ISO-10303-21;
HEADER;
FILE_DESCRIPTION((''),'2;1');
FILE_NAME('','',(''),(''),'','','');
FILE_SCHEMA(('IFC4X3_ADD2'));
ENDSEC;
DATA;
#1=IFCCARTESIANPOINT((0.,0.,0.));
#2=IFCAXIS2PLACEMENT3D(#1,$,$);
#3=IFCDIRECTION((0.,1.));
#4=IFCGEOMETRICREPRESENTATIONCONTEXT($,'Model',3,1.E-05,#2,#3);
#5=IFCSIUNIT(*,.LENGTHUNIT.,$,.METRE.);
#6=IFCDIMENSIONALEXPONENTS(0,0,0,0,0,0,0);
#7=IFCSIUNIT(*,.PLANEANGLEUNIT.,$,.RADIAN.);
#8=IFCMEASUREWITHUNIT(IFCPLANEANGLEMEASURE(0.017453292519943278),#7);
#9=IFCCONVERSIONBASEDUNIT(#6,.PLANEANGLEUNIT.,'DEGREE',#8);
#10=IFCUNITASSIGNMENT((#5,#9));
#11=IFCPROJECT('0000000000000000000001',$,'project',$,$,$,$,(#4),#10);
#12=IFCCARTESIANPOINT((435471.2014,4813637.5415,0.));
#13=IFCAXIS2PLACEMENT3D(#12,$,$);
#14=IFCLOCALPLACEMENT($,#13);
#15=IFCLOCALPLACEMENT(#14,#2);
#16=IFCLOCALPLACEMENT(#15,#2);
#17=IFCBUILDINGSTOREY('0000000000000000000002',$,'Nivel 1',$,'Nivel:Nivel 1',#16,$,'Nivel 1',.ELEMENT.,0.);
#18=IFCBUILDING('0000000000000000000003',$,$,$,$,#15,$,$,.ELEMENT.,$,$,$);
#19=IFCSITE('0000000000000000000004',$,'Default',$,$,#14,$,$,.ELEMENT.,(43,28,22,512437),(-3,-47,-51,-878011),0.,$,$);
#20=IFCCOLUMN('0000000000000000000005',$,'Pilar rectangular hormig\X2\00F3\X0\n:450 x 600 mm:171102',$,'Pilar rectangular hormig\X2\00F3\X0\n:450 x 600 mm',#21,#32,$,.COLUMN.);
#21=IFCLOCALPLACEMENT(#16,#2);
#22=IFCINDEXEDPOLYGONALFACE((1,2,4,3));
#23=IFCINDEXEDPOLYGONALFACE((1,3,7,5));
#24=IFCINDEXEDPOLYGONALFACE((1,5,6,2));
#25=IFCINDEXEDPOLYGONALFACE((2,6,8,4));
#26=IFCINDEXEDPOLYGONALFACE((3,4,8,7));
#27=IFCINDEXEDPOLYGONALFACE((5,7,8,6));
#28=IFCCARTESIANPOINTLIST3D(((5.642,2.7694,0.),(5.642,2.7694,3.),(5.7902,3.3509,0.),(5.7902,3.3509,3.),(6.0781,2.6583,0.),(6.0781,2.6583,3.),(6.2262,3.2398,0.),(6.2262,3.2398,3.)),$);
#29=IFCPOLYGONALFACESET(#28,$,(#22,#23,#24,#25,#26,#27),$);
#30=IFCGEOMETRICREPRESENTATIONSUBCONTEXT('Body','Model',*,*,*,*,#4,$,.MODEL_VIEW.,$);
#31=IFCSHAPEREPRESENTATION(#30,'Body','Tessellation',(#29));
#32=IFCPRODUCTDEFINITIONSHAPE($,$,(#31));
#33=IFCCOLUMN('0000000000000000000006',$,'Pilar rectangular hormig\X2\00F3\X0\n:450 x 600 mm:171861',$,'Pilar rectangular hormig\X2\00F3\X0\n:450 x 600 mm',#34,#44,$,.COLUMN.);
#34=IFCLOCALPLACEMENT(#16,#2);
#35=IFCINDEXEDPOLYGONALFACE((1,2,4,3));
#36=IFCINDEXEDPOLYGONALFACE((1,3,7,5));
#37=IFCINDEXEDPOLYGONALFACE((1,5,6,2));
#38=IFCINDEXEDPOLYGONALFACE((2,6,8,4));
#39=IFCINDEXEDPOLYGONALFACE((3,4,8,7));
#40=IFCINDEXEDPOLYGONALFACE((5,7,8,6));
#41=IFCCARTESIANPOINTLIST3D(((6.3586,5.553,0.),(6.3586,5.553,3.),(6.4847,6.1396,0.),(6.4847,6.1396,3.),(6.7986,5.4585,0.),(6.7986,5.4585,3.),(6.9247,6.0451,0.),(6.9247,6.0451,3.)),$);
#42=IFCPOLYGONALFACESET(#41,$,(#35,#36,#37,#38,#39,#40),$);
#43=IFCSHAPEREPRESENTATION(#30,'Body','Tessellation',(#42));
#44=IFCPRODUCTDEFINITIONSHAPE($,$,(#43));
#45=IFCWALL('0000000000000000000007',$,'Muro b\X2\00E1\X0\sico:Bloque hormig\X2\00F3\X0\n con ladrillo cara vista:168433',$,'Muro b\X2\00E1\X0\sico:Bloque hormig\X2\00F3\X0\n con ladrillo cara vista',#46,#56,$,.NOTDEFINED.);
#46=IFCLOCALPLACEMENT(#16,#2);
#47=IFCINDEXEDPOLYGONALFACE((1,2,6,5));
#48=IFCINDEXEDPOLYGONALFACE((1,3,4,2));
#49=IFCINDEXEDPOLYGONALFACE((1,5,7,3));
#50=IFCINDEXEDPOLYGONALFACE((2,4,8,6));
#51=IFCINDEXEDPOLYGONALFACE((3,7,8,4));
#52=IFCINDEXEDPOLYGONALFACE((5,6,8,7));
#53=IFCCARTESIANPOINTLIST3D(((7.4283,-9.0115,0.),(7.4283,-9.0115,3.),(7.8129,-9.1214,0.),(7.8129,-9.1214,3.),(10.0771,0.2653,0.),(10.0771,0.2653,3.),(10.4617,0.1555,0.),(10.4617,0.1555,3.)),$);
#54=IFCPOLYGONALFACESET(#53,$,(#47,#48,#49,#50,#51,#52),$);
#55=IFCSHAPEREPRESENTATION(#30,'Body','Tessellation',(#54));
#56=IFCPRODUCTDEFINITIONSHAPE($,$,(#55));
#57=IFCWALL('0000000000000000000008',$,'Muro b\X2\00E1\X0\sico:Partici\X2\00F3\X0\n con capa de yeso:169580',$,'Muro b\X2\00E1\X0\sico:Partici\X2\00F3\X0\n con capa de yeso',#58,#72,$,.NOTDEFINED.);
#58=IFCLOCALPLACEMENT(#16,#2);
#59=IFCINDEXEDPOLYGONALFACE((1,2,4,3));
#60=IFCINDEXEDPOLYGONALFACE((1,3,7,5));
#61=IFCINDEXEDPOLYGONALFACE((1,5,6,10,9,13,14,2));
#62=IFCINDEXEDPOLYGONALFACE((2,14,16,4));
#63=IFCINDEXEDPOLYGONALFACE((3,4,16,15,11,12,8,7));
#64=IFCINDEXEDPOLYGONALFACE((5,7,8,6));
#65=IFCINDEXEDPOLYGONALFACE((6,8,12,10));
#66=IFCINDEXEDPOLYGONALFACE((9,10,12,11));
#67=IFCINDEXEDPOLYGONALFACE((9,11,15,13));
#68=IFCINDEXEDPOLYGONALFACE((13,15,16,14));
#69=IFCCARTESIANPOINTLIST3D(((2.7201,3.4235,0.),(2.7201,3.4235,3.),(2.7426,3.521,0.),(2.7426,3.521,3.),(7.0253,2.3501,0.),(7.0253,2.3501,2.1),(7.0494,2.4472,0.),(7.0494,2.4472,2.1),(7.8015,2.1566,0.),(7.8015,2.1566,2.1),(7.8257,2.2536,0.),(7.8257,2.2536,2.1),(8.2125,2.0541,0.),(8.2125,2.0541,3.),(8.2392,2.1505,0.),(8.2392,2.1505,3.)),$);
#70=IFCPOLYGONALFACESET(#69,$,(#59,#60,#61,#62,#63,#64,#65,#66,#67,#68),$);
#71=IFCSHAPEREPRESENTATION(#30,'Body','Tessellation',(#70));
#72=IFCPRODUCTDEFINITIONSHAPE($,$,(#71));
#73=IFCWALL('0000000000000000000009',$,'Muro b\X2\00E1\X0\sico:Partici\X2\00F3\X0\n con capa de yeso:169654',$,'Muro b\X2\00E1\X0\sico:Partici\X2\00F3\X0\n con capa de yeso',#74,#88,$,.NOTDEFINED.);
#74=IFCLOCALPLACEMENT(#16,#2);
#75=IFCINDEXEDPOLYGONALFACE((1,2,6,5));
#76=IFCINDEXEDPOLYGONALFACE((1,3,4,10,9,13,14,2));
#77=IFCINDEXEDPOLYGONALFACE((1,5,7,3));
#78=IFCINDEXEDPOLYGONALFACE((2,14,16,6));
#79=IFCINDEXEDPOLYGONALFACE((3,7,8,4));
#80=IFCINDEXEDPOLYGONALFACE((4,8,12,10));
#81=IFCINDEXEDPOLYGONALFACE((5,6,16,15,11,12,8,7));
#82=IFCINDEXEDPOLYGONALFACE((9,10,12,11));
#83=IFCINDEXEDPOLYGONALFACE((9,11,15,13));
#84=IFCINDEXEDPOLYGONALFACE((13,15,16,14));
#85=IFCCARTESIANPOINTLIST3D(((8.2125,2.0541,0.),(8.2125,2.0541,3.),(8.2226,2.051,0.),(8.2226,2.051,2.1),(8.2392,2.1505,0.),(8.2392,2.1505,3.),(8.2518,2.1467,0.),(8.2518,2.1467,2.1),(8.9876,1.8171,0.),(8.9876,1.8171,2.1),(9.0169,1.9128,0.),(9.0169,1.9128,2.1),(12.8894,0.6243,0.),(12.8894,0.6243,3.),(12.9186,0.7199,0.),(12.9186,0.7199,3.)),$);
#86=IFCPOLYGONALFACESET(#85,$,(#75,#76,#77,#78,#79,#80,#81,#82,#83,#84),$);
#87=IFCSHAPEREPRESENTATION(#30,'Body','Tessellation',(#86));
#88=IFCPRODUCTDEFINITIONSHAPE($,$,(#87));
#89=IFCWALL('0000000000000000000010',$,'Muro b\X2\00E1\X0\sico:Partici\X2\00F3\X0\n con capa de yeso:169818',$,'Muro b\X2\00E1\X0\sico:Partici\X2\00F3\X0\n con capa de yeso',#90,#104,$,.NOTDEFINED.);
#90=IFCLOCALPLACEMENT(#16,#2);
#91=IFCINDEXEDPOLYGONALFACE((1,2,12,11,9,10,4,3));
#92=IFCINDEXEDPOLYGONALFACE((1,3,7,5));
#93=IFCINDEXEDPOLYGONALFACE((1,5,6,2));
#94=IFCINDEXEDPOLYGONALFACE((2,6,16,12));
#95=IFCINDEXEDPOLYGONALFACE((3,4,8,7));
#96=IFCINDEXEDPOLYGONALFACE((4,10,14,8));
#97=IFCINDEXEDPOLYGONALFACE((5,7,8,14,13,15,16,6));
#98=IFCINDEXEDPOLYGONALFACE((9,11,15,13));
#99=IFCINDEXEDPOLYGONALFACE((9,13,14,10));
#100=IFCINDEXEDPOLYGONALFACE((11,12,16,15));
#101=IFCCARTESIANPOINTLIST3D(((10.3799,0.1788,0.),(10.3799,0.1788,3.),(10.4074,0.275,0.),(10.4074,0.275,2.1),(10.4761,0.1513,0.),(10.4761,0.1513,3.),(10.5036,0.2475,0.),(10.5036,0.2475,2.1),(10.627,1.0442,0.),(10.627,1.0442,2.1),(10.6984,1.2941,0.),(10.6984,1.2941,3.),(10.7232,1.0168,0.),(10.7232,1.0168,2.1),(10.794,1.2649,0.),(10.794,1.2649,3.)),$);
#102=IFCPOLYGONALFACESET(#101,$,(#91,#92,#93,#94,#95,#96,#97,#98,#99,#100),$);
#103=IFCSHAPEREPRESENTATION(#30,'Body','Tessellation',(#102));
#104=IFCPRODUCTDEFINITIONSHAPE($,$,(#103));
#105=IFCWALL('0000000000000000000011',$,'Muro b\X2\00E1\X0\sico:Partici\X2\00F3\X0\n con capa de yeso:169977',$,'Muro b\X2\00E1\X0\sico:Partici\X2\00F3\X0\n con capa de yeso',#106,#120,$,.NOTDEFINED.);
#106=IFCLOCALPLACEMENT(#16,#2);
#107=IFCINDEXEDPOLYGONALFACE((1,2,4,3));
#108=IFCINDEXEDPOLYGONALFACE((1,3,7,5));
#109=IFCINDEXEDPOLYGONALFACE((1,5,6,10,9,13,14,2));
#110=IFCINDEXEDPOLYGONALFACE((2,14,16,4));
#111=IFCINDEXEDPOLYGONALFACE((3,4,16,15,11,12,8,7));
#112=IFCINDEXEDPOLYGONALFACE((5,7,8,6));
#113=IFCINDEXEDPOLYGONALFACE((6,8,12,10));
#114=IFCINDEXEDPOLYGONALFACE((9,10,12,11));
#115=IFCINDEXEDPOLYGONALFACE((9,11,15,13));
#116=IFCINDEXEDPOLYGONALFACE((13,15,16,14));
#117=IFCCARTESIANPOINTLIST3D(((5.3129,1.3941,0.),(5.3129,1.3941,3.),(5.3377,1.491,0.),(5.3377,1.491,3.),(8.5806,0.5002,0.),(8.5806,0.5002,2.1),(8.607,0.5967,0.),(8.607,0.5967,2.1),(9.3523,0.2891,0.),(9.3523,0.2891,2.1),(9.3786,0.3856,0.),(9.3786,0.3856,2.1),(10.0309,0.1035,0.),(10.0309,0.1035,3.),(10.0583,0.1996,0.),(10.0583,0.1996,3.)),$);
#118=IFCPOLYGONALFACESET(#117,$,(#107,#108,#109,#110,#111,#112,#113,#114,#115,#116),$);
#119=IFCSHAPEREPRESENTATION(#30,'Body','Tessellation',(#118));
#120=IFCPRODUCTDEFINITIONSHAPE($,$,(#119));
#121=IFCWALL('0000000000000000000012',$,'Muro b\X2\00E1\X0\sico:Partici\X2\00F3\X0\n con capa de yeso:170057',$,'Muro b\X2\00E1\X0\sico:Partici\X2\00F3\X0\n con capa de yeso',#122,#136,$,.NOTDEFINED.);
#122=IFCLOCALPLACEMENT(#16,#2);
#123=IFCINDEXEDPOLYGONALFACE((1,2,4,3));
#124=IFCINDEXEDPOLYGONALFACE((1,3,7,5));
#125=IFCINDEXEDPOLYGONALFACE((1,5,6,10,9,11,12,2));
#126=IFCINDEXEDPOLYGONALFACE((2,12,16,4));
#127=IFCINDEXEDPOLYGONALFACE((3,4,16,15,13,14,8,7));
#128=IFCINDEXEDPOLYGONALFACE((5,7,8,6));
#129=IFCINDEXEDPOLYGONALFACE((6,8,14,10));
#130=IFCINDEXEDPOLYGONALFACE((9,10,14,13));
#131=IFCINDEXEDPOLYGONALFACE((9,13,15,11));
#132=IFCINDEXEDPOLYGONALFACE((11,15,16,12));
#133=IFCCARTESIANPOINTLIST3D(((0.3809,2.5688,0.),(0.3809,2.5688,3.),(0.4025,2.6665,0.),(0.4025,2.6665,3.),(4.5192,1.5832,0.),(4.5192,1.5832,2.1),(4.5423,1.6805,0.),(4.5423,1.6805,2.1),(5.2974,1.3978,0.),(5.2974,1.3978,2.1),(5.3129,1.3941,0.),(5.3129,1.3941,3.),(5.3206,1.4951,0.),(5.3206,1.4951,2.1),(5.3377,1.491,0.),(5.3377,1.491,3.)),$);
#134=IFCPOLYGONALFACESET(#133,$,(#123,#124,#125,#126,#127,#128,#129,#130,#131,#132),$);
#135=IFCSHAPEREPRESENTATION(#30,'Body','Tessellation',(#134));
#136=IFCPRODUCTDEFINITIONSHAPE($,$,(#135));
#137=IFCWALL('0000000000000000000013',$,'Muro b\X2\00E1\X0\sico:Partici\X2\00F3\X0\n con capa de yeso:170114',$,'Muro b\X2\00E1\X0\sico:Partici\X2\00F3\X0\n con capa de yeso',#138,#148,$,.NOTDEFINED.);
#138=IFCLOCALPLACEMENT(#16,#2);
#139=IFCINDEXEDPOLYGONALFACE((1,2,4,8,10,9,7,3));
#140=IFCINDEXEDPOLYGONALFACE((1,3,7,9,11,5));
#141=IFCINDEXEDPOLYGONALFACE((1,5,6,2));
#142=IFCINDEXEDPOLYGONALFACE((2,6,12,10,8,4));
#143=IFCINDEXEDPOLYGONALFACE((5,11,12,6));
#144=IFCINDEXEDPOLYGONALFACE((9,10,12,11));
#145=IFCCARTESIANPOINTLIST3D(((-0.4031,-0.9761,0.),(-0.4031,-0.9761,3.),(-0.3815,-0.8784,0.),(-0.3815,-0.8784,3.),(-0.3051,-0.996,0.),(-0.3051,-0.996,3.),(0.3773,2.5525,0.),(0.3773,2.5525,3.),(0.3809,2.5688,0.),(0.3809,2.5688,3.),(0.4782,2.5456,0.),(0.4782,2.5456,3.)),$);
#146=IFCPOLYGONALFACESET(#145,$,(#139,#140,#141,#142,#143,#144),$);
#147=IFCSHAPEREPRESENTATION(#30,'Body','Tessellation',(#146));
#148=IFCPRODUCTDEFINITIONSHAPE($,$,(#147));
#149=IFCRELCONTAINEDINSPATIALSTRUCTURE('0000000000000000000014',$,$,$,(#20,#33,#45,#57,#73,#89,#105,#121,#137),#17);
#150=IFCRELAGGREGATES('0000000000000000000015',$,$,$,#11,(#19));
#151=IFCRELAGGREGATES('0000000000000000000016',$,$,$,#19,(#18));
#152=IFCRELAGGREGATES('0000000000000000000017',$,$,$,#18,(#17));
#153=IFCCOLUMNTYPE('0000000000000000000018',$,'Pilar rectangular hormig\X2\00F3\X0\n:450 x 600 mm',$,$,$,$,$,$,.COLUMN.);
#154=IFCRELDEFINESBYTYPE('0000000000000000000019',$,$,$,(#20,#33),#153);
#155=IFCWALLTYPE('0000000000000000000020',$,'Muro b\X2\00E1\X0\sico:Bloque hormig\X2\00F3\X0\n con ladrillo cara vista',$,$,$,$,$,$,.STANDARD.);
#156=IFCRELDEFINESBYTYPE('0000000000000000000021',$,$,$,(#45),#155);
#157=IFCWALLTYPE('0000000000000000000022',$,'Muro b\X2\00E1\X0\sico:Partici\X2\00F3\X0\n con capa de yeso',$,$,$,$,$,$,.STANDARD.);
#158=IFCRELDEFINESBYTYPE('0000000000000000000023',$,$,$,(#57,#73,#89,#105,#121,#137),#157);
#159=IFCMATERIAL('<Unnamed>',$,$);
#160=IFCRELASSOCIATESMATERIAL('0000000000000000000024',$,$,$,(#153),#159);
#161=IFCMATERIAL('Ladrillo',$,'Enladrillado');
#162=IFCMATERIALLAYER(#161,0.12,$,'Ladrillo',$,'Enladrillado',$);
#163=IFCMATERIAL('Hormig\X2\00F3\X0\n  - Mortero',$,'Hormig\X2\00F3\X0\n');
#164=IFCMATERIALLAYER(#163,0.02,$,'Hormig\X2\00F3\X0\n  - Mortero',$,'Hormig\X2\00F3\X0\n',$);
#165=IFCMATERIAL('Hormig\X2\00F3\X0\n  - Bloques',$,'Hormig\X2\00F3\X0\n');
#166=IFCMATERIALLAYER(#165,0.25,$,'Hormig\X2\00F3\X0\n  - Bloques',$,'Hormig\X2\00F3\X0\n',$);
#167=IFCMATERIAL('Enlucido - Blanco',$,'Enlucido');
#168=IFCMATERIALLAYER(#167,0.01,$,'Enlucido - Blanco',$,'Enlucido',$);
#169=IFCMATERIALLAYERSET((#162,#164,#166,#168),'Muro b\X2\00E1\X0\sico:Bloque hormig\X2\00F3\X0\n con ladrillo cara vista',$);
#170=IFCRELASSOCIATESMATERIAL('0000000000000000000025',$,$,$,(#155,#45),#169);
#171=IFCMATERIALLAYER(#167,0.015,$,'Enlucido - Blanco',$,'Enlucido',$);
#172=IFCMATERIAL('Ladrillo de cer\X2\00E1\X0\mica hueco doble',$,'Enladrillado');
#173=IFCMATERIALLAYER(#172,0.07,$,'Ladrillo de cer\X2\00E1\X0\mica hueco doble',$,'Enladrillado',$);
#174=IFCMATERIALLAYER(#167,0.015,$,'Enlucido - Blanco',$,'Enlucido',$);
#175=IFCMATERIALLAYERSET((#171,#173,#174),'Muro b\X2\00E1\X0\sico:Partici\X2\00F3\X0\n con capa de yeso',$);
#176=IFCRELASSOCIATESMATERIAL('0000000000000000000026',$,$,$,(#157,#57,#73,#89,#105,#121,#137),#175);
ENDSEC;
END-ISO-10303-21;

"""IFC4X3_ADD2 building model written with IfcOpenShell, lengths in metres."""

from ifc_helpers import new_model, entity, si_unit, converted_unit, direction, frame, frame_2d, origin, origin_2d_with_axis, place, context, subcontext, project, spatial, polyline, rectangle, outline, extrude, source, transform, mapped, material, layer, layer_set, material_profile, profile_set, type_object, type_shapes, element, save


model = new_model("IFC4X3_ADD2")

# Units and contexts
model_context = context("Model", 3, precision=1e-05, world=origin(), true_north=direction((0.0, 1.0)))
body_context = subcontext(model_context, "Body", "Model", "MODEL_VIEW")
ifc_project = project(units=[si_unit("LENGTHUNIT", "METRE"), converted_unit("PLANEANGLEUNIT", "DEGREE", entity("IfcPlaneAngleMeasure", 0.017453292519943278), si_unit("PLANEANGLEUNIT", "RADIAN"), dimensions=[0, 0, 0, 0, 0, 0, 0])], contexts=[model_context])

# Site, building, storey
site_placement = place(None, frame((435471.2014, 4813637.5415, 0.0)))
site = spatial("IfcSite", under=ifc_project, at=site_placement, Name="Default", CompositionType="ELEMENT", RefLatitude=(43, 28, 22, 512437), RefLongitude=(-3, -47, -51, -878011), RefElevation=0.0)
building_placement = place(site_placement, origin())
building = spatial("IfcBuilding", under=site, at=building_placement, CompositionType="ELEMENT")
storey_placement = place(building_placement, origin())
storey = spatial("IfcBuildingStorey", under=building, at=storey_placement, Name="Nivel 1", ObjectType="Nivel:Nivel 1", LongName="Nivel 1", CompositionType="ELEMENT", Elevation=0.0)

# Columns
ifc_material_1 = material(Name="<Unnamed>")
ifc_material_profile = material_profile(ifc_material_1, rectangle(XDim=0.45, YDim=0.6, at=origin_2d_with_axis()), Name="450 x 600 mm")
ifc_profile_set = profile_set([ifc_material_profile], Name="450 x 600 mm")
column_type = type_object("IfcColumnType", Name="Pilar rectangular hormigón:450 x 600 mm", PredefinedType="COLUMN", material=ifc_profile_set)
shared_shape_1 = source(origin(), body_context, "Body", "SweptSolid", [
    extrude(rectangle(XDim=0.45, YDim=0.6, at=origin_2d_with_axis()), frame((0.0, 0.0, 0.0), z_axis=(0.0, 0.0, 1.0), x_axis=(-1.0, 0.0, 0.0)), (0.0, 0.0, 1.0), 3.0),
])
type_shapes(column_type, [shared_shape_1])
for number, where, z_axis, x_axis, name in (
    (1, (5.9341, 3.0046, 0.0), (0.0, 0.0, 1.0), (0.969039, -0.246908, 0.0), "Pilar rectangular hormigón:450 x 600 mm:171102"),
    (2, (6.6416, 5.799, 0.0), (0.0, 0.0, 1.0), (0.977667, -0.210159, 0.0), "Pilar rectangular hormigón:450 x 600 mm:171861"),
):
    element("IfcColumn", number, at=place(storey_placement, frame(where, z_axis=z_axis, x_axis=x_axis)), inside=storey, type_object=column_type, Name=name, ObjectType="Pilar rectangular hormigón:450 x 600 mm", PredefinedType="COLUMN", context=body_context, shape_type="MappedRepresentation", body=[
        mapped(shared_shape_1, transform((0.0, 0.0, 0.0), scale=1.0)),
    ])

# Shared definitions
ifc_material_2 = material(Name="Enlucido - Blanco", Category="Enlucido")

# Wall
ifc_material_3 = material(Name="Ladrillo", Category="Enladrillado")
ifc_layer_1 = layer(ifc_material_3, 0.12, Name="Ladrillo", Category="Enladrillado")
ifc_material_4 = material(Name="Hormigón  - Mortero", Category="Hormigón")
ifc_layer_2 = layer(ifc_material_4, 0.02, Name="Hormigón  - Mortero", Category="Hormigón")
ifc_material_5 = material(Name="Hormigón  - Bloques", Category="Hormigón")
ifc_layer_3 = layer(ifc_material_5, 0.25, Name="Hormigón  - Bloques", Category="Hormigón")
ifc_layer_4 = layer(ifc_material_2, 0.01, Name="Enlucido - Blanco", Category="Enlucido")
ifc_layer_set_1 = layer_set([ifc_layer_1, ifc_layer_2, ifc_layer_3, ifc_layer_4], Name="Muro básico:Bloque hormigón con ladrillo cara vista")
wall_type_1 = type_object("IfcWallType", Name="Muro básico:Bloque hormigón con ladrillo cara vista", PredefinedType="STANDARD", material=ifc_layer_set_1)
wall_1_placement = place(storey_placement, frame((10.2694, 0.2104, 0.0), z_axis=(0.0, 0.0, 1.0), x_axis=(-0.274552, -0.961572, 0.0)))
element("IfcWall", 3, at=wall_1_placement, inside=storey, type_object=wall_type_1, material=ifc_layer_set_1, Name="Muro básico:Bloque hormigón con ladrillo cara vista:168433", ObjectType="Muro básico:Bloque hormigón con ladrillo cara vista", PredefinedType="NOTDEFINED", context=body_context, shape_type="SweptSolid", body=[
    extrude(rectangle(XDim=9.6476, YDim=0.4, at=frame_2d((4.8238, 0.0), x_axis=(-1.0, 0.0))), origin(), (0.0, 0.0, 1.0), 3.0),
])

# Walls, openings
ifc_layer_5 = layer(ifc_material_2, 0.015, Name="Enlucido - Blanco", Category="Enlucido")
ifc_material_6 = material(Name="Ladrillo de cerámica hueco doble", Category="Enladrillado")
ifc_layer_6 = layer(ifc_material_6, 0.07, Name="Ladrillo de cerámica hueco doble", Category="Enladrillado")
ifc_layer_7 = layer(ifc_material_2, 0.015, Name="Enlucido - Blanco", Category="Enlucido")
ifc_layer_set_2 = layer_set([ifc_layer_5, ifc_layer_6, ifc_layer_7], Name="Muro básico:Partición con capa de yeso")
wall_type_2 = type_object("IfcWallType", Name="Muro básico:Partición con capa de yeso", PredefinedType="STANDARD", material=ifc_layer_set_2)
wall_2_placement = place(storey_placement, frame((2.7305, 3.4725, 0.0), z_axis=(0.0, 0.0, 1.0), x_axis=(0.970296, -0.241922, 0.0)))
wall_2 = element("IfcWall", 4, at=wall_2_placement, inside=storey, type_object=wall_type_2, material=ifc_layer_set_2, Name="Muro básico:Partición con capa de yeso:169580", ObjectType="Muro básico:Partición con capa de yeso", PredefinedType="NOTDEFINED", context=body_context, shape_type="SweptSolid", body=[
    extrude(outline(polyline([(0.0018, -0.05), (5.6622, -0.05), (5.6648, 0.05), (5.4827, 0.05), (5.3826, 0.05), (0.4693, 0.05), (0.3693, 0.05), (0.0, 0.05), (0.0018, -0.05)])), origin(), (0.0, 0.0, 1.0), 3.0),
])
opening_1_placement = place(wall_2_placement, frame((4.4387, -0.05, 0.0)))
element("IfcOpeningElement", 5, at=opening_1_placement, cuts=wall_2, PredefinedType="OPENING", context=body_context, shape_type="SweptSolid", body=[
    extrude(rectangle(XDim=2.1, YDim=0.8, at=frame_2d((1.05, 0.4), x_axis=(1.0, 0.0))), frame((0.0, 0.0, 0.0), z_axis=(0.0, 1.0, 0.0), x_axis=(0.0, 0.0, 1.0)), (0.0, 0.0, 1.0), 0.1),
])
wall_3_placement = place(storey_placement, frame((8.2246, 2.1027, 0.0), z_axis=(0.0, 0.0, 1.0), x_axis=(0.956305, -0.292372, 0.0)))
wall_3 = element("IfcWall", 6, at=wall_3_placement, inside=storey, type_object=wall_type_2, material=ifc_layer_set_2, Name="Muro básico:Partición con capa de yeso:169654", ObjectType="Muro básico:Partición con capa de yeso", PredefinedType="NOTDEFINED", context=body_context, shape_type="SweptSolid", body=[
    extrude(outline(polyline([(0.0026, -0.05), (2.6022, -0.05), (2.7022, -0.05), (4.8932, -0.05), (4.8932, 0.05), (0.0, 0.05), (0.0026, -0.05)])), origin(), (0.0, 0.0, 1.0), 3.0),
])
opening_2_placement = place(wall_3_placement, frame((0.0132, -0.05, 0.0)))
element("IfcOpeningElement", 7, at=opening_2_placement, cuts=wall_3, PredefinedType="OPENING", context=body_context, shape_type="SweptSolid", body=[
    extrude(rectangle(XDim=2.1, YDim=0.8, at=frame_2d((1.05, 0.4), x_axis=(1.0, 0.0))), frame((0.0, 0.0, 0.0), z_axis=(0.0, 1.0, 0.0), x_axis=(0.0, 0.0, 1.0)), (0.0, 0.0, 1.0), 0.1),
])
wall_4_placement = place(storey_placement, frame((10.7465, 1.2804, 0.0), z_axis=(0.0, 0.0, 1.0), x_axis=(-0.274552, -0.961572, 0.0)))
wall_4 = element("IfcWall", 8, at=wall_4_placement, inside=storey, type_object=wall_type_2, material=ifc_layer_set_2, Name="Muro básico:Partición con capa de yeso:169818", ObjectType="Muro básico:Partición con capa de yeso", PredefinedType="NOTDEFINED", context=body_context, shape_type="SweptSolid", body=[
    extrude(outline(polyline([(0.0, -0.05), (1.1599, -0.05), (1.1599, 0.035), (1.1599, 0.05), (0.0019, 0.05), (0.0, -0.05)])), origin(), (0.0, 0.0, 1.0), 3.0),
])
opening_3_placement = place(wall_4_placement, frame((0.2599, -0.05, 0.0)))
element("IfcOpeningElement", 9, at=opening_3_placement, cuts=wall_4, PredefinedType="OPENING", context=body_context, shape_type="SweptSolid", body=[
    extrude(rectangle(XDim=2.1, YDim=0.8, at=frame_2d((1.05, 0.4), x_axis=(1.0, 0.0))), frame((0.0, 0.0, 0.0), z_axis=(0.0, 1.0, 0.0), x_axis=(0.0, 0.0, 1.0)), (0.0, 0.0, 1.0), 0.1),
])
wall_5_placement = place(storey_placement, frame((10.0451, 0.1514, 0.0), z_axis=(0.0, 0.0, 1.0), x_axis=(-0.964559, 0.263866, 0.0)))
wall_5 = element("IfcWall", 10, at=wall_5_placement, inside=storey, type_object=wall_type_2, material=ifc_layer_set_2, Name="Muro básico:Partición con capa de yeso:169977", ObjectType="Muro básico:Partición con capa de yeso", PredefinedType="NOTDEFINED", context=body_context, shape_type="SweptSolid", body=[
    extrude(outline(polyline([(0.0, -0.05), (4.8941, -0.05), (4.8925, 0.05), (0.0011, 0.05), (0.0, -0.05)])), origin(), (0.0, 0.0, 1.0), 3.0),
])
opening_4_placement = place(wall_5_placement, frame((0.7046, -0.05, 0.0)))
element("IfcOpeningElement", 11, at=opening_4_placement, cuts=wall_5, PredefinedType="OPENING", context=body_context, shape_type="SweptSolid", body=[
    extrude(rectangle(XDim=2.1, YDim=0.8, at=frame_2d((1.05, 0.4), x_axis=(1.0, 0.0))), frame((0.0, 0.0, 0.0), z_axis=(0.0, 1.0, 0.0), x_axis=(0.0, 0.0, 1.0)), (0.0, 0.0, 1.0), 0.1),
])
wall_6_placement = place(storey_placement, frame((5.3261, 1.4424, 0.0), z_axis=(0.0, 0.0, 1.0), x_axis=(-0.972789, 0.231693, 0.0)))
wall_6 = element("IfcWall", 12, at=wall_6_placement, inside=storey, type_object=wall_type_2, material=ifc_layer_set_2, Name="Muro básico:Partición con capa de yeso:170057", ObjectType="Muro básico:Partición con capa de yeso", PredefinedType="NOTDEFINED", context=body_context, shape_type="SweptSolid", body=[
    extrude(outline(polyline([(0.0, -0.05), (5.0732, -0.05), (5.0729, -0.0333), (5.0716, 0.05), (4.9716, 0.05), (0.0017, 0.05), (0.0, -0.05)])), origin(), (0.0, 0.0, 1.0), 3.0),
])
opening_5_placement = place(wall_6_placement, frame((0.0176, -0.05, 0.0)))
element("IfcOpeningElement", 13, at=opening_5_placement, cuts=wall_6, PredefinedType="OPENING", context=body_context, shape_type="SweptSolid", body=[
    extrude(rectangle(XDim=2.1, YDim=0.8, at=frame_2d((1.05, 0.4), x_axis=(1.0, 0.0))), frame((0.0, 0.0, 0.0), z_axis=(0.0, 1.0, 0.0), x_axis=(0.0, 0.0, 1.0)), (0.0, 0.0, 1.0), 0.1),
])

# Wall
wall_7_placement = place(storey_placement, frame((0.4297, 2.558, 0.0), z_axis=(0.0, 0.0, 1.0), x_axis=(-0.215934, -0.976408, 0.0)))
element("IfcWall", 14, at=wall_7_placement, inside=storey, type_object=wall_type_2, material=ifc_layer_set_2, Name="Muro básico:Partición con capa de yeso:170114", ObjectType="Muro básico:Partición con capa de yeso", PredefinedType="NOTDEFINED", context=body_context, shape_type="SweptSolid", body=[
    extrude(outline(polyline([(3.6305, -0.05), (3.6289, 0.05), (0.0016, 0.05), (0.0, -0.05), (0.0167, -0.05), (3.5305, -0.05), (3.6305, -0.05)])), origin(), (0.0, 0.0, 1.0), 3.0),
])

save(model, "model.ifc")
